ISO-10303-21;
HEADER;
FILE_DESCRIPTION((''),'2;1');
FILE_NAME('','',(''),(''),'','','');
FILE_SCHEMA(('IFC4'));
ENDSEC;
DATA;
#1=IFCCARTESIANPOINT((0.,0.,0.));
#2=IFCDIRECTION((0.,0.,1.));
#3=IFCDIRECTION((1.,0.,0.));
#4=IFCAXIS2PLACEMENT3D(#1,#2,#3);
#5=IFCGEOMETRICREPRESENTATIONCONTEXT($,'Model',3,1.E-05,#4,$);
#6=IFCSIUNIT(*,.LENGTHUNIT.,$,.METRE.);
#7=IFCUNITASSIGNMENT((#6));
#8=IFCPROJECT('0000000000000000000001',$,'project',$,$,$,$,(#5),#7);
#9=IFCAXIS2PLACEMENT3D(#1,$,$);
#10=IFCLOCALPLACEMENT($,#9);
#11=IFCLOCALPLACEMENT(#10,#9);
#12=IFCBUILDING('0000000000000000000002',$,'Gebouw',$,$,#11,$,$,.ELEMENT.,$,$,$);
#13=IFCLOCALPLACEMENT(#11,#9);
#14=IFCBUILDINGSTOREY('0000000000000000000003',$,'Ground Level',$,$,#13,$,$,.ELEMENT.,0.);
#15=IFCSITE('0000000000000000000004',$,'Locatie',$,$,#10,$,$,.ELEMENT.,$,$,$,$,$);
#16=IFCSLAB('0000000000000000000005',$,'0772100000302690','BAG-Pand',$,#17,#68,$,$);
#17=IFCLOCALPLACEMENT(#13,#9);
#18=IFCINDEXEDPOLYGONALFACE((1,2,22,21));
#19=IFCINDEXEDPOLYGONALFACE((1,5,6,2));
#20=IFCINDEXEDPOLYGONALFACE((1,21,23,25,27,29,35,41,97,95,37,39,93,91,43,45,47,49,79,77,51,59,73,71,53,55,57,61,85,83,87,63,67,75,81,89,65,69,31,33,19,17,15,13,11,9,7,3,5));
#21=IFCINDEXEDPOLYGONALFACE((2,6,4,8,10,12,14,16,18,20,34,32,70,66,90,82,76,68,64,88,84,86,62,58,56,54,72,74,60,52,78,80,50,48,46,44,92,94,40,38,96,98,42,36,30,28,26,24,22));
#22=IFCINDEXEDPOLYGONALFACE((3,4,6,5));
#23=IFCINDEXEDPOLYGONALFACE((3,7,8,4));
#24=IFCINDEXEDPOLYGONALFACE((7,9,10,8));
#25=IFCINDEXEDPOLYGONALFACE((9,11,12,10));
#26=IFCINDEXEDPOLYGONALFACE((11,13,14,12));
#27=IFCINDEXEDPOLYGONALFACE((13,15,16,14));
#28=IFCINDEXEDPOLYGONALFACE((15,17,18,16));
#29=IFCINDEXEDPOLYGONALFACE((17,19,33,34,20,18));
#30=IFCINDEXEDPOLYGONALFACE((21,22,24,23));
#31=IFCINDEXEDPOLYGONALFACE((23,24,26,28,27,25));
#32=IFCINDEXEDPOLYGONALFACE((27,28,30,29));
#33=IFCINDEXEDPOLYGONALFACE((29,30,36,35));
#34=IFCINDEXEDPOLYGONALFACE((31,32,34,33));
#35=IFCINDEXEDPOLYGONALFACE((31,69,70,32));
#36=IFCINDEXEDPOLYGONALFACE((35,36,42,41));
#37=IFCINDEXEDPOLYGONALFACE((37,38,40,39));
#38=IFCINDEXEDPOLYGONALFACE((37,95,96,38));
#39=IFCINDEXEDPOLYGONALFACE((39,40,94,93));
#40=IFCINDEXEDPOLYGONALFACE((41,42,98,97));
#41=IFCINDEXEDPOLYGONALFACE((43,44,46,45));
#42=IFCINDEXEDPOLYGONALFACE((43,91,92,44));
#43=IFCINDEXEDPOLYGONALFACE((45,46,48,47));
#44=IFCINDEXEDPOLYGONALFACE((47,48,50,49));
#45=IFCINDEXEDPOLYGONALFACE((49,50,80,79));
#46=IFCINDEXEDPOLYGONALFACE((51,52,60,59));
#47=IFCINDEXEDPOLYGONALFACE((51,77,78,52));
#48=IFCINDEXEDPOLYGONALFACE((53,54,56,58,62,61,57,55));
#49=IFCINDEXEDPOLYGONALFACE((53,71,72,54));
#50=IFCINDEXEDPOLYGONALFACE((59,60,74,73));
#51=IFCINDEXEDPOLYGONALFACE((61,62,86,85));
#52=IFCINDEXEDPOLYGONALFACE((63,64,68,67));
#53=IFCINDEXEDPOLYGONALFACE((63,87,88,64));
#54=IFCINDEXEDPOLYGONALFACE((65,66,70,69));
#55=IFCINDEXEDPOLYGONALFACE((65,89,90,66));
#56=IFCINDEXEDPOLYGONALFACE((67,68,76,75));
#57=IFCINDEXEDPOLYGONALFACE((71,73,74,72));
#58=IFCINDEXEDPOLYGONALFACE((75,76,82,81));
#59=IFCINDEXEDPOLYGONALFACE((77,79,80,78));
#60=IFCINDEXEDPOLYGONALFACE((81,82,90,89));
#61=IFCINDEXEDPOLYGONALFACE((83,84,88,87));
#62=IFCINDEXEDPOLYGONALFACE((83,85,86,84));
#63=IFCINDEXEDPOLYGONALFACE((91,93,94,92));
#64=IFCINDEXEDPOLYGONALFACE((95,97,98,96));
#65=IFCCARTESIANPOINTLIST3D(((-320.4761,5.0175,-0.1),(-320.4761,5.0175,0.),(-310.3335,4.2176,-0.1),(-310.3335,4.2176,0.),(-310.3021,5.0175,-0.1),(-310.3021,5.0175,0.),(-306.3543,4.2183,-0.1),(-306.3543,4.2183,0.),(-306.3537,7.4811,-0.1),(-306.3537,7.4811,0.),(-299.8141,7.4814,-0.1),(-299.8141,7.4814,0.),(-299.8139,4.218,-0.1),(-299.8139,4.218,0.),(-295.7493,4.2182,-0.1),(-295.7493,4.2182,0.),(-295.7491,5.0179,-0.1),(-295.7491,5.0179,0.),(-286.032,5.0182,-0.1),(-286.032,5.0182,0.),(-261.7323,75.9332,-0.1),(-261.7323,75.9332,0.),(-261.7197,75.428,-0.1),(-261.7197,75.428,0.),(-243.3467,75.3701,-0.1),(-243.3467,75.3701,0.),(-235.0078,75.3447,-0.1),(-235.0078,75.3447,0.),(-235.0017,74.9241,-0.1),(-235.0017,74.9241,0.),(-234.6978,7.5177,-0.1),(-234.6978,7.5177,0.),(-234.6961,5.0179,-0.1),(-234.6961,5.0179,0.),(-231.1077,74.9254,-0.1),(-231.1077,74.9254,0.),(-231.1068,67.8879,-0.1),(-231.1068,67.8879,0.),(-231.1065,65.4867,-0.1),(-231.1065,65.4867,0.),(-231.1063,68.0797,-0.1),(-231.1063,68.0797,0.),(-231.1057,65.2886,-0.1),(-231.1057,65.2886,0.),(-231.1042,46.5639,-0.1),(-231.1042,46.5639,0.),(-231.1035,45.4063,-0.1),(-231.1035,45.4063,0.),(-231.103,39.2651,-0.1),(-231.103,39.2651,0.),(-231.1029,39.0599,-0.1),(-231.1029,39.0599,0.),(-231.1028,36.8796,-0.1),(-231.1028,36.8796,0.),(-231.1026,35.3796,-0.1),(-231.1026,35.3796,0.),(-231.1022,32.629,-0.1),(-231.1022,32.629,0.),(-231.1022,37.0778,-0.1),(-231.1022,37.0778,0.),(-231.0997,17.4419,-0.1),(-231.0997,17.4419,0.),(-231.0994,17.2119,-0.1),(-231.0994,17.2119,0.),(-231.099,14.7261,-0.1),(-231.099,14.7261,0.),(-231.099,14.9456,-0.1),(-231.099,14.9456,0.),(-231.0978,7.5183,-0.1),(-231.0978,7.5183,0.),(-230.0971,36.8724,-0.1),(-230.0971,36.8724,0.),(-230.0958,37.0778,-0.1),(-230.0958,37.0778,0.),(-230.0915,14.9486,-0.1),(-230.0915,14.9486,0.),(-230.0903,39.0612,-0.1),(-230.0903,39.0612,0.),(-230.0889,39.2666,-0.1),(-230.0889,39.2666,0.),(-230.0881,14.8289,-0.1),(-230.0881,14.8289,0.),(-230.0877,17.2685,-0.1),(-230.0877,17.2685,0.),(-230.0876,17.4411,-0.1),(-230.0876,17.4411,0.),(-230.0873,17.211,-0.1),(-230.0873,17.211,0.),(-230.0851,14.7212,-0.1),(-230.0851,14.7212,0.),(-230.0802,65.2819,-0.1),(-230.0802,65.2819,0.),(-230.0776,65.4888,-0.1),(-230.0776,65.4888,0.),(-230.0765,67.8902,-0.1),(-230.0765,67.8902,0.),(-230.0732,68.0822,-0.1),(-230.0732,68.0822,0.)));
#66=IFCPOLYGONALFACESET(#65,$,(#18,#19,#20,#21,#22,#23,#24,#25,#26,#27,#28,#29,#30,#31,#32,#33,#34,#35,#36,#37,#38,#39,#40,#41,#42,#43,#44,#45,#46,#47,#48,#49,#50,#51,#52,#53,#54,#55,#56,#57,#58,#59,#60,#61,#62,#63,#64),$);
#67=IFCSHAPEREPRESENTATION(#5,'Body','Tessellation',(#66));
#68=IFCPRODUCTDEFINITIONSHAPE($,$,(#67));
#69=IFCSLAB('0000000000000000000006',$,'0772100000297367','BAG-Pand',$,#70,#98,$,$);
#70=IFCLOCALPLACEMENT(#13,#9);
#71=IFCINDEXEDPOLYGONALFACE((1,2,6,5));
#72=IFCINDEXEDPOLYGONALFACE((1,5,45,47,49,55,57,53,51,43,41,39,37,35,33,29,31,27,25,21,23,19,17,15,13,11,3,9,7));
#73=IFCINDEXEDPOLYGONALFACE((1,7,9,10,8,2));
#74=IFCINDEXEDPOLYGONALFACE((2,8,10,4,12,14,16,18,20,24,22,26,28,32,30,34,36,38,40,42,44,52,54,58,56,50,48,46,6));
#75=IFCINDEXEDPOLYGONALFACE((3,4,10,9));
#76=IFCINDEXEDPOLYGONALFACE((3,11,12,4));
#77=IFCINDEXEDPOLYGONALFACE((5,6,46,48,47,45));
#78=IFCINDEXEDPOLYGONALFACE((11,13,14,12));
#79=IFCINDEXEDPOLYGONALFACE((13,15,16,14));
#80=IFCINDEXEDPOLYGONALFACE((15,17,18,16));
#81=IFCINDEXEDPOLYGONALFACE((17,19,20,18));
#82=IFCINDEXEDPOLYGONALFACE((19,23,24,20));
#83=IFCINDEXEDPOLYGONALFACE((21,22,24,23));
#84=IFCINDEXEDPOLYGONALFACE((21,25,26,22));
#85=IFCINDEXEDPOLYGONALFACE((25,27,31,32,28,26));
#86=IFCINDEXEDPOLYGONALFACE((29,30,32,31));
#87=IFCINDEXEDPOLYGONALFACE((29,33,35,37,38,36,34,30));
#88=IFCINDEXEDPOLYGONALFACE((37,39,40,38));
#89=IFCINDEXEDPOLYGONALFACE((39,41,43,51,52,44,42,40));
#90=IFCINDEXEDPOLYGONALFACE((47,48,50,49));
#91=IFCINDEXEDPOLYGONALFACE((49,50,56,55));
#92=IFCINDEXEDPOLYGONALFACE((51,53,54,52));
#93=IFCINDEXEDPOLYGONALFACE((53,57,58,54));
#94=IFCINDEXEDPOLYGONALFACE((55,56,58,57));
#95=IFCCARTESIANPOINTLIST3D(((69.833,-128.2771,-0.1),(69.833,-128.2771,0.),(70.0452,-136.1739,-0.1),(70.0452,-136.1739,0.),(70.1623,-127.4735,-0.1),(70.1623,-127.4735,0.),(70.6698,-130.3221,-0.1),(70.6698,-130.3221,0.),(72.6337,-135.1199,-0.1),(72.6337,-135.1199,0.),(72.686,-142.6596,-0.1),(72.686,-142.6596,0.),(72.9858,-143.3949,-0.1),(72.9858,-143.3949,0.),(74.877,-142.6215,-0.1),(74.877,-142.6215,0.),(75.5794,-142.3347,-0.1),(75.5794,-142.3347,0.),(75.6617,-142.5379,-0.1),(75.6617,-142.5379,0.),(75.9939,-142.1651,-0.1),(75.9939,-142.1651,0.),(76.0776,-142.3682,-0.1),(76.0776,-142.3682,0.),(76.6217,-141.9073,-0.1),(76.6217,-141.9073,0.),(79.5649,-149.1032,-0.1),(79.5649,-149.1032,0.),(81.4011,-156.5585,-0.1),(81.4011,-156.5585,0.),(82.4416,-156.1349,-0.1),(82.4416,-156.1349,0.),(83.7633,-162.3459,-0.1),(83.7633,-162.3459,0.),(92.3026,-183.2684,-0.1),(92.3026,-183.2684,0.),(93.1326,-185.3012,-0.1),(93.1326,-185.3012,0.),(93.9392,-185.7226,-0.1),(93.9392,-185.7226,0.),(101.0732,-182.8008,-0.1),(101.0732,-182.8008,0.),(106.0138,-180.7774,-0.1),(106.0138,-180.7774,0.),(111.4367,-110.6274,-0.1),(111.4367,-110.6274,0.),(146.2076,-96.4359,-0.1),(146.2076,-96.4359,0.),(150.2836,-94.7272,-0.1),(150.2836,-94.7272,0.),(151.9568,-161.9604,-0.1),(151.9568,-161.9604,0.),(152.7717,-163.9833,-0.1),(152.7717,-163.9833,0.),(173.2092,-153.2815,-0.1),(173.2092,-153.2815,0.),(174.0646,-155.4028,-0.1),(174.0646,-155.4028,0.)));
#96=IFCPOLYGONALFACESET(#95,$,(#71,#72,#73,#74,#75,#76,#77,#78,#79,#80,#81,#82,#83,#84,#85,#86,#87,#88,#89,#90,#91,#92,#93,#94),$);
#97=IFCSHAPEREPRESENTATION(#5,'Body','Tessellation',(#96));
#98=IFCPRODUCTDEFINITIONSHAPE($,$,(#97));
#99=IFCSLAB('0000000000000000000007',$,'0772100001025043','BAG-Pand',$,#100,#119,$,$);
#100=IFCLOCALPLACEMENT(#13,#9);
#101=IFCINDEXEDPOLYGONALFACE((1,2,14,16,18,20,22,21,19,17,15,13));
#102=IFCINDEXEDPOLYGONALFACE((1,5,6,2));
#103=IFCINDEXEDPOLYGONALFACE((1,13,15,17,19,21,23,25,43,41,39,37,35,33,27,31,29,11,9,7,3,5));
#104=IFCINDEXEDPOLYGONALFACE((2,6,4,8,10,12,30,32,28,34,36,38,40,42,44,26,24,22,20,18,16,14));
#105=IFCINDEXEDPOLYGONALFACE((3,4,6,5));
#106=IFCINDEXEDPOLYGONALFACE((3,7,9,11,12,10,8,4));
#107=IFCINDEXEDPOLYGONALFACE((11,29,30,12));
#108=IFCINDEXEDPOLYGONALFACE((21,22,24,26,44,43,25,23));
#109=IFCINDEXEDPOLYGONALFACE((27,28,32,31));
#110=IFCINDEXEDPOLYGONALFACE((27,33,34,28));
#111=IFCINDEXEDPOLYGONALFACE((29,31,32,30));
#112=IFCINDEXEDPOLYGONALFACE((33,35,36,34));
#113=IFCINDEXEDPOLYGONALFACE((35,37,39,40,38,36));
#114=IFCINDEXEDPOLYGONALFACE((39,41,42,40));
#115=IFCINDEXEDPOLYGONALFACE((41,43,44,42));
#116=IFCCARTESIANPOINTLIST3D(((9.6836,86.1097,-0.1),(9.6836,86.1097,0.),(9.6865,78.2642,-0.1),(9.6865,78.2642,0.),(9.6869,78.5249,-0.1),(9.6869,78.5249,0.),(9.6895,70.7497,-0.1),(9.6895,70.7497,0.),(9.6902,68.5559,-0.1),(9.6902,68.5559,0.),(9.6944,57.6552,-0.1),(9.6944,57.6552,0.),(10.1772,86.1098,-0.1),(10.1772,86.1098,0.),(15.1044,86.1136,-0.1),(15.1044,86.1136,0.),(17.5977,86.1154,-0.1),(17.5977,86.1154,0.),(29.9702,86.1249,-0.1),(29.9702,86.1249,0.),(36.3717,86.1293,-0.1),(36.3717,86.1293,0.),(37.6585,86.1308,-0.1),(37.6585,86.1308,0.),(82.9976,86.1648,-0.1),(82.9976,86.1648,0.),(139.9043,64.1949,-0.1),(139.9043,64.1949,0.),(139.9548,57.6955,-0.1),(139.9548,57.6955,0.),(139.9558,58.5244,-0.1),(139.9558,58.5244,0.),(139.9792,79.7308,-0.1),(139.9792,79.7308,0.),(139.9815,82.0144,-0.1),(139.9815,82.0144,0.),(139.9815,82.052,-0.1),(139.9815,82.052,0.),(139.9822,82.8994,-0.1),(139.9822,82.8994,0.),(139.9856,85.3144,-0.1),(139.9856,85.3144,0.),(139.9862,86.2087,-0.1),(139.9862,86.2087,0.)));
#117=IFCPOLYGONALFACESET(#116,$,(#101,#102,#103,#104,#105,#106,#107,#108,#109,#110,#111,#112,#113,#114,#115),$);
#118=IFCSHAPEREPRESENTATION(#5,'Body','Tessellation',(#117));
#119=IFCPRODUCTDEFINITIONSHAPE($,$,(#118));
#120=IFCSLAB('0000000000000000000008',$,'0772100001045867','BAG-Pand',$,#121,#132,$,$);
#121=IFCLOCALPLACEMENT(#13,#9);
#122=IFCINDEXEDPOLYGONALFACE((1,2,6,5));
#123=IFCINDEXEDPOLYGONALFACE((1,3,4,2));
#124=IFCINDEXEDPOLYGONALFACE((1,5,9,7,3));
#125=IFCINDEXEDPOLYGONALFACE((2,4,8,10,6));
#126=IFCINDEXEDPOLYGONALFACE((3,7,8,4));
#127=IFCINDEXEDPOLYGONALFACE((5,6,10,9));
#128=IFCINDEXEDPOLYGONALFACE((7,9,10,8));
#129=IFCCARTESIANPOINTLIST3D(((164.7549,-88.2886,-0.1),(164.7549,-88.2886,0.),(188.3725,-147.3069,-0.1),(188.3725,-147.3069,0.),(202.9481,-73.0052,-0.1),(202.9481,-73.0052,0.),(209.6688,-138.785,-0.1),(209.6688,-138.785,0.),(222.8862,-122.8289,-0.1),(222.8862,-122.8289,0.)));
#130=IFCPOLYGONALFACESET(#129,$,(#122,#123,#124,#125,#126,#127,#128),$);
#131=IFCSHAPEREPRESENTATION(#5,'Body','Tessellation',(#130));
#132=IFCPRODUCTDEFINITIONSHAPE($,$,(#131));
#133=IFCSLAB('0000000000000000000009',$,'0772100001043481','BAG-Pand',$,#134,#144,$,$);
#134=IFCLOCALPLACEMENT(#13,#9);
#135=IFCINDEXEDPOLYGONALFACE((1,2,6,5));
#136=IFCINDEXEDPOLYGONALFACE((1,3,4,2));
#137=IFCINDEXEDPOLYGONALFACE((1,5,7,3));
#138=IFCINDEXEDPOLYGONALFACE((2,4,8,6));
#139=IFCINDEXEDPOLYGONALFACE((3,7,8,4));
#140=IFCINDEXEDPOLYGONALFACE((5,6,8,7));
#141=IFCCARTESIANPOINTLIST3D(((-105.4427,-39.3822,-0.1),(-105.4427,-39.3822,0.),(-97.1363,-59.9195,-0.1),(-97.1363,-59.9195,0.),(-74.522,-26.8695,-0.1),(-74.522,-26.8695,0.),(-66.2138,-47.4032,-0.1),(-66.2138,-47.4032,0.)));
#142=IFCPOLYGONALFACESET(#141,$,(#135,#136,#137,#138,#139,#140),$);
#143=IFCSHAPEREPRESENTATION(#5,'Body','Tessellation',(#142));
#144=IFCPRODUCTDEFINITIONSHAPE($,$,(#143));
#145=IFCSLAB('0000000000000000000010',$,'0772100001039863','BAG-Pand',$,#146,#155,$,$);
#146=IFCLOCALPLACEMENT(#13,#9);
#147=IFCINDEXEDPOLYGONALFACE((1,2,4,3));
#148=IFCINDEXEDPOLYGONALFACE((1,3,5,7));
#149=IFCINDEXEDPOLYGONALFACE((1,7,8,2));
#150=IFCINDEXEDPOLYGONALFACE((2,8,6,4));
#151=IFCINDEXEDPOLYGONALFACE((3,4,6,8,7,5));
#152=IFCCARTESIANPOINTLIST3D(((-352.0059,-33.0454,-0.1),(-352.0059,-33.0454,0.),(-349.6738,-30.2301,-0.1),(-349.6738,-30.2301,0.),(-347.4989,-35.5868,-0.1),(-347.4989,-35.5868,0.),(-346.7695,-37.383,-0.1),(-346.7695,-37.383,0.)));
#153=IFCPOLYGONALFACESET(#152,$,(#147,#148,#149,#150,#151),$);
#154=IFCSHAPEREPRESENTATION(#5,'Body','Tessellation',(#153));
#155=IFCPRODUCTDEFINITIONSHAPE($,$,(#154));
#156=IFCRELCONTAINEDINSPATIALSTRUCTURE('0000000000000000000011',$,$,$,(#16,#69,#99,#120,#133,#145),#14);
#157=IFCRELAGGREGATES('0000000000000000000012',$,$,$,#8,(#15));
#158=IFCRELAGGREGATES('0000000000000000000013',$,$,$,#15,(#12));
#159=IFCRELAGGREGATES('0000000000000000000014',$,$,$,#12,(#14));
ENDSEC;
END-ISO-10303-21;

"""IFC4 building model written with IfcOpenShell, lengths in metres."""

from ifc_helpers import new_model, si_unit, frame, origin, origin_with_axes, place, context, project, spatial, polyline, outline, extrude, element, save


model = new_model("IFC4")

# Units and contexts
model_context = context("Model", 3, precision=1e-05, world=origin_with_axes())
ifc_project = project(units=[si_unit("LENGTHUNIT", "METRE")], contexts=[model_context])

# Site, building, storey
site_placement = place(None, origin())
site = spatial("IfcSite", under=ifc_project, at=site_placement, Name="Locatie", CompositionType="ELEMENT")
building_placement = place(site_placement, origin())
building = spatial("IfcBuilding", under=site, at=building_placement, Name="Gebouw", CompositionType="ELEMENT")
storey_placement = place(building_placement, origin())
storey = spatial("IfcBuildingStorey", under=building, at=storey_placement, Name="Ground Level", CompositionType="ELEMENT", Elevation=0.0)

# Slabs
slab_1_placement = place(storey_placement, origin())
element("IfcSlab", 1, at=slab_1_placement, inside=storey, Name="0772100000302690", Description="BAG-Pand", context=model_context, shape_type="SweptSolid", body=[
    extrude(outline(polyline([(-261.7197, 75.428), (-243.3467, 75.3701), (-235.0078, 75.3447), (-235.0017, 74.9241), (-231.1077, 74.9254), (-231.1063, 68.0797), (-230.0732, 68.0822), (-230.0765, 67.8902), (-231.1068, 67.8879), (-231.1065, 65.4867), (-230.0776, 65.4888), (-230.0802, 65.2819), (-231.1057, 65.2886), (-231.1042, 46.5639), (-231.1035, 45.4063), (-231.103, 39.2651), (-230.0889, 39.2666), (-230.0903, 39.0612), (-231.1029, 39.0599), (-231.1022, 37.0778), (-230.0958, 37.0778), (-230.0971, 36.8724), (-231.1028, 36.8796), (-231.1026, 35.3796), (-231.1022, 32.629), (-231.0997, 17.4419), (-230.0876, 17.4411), (-230.0877, 17.2685), (-230.0873, 17.211), (-231.0994, 17.2119), (-231.099, 14.9456), (-230.0915, 14.9486), (-230.0881, 14.8289), (-230.0851, 14.7212), (-231.099, 14.7261), (-231.0978, 7.5183), (-234.6978, 7.5177), (-234.6961, 5.0179), (-286.032, 5.0182), (-295.7491, 5.0179), (-295.7493, 4.2182), (-299.8139, 4.218), (-299.8141, 7.4814), (-306.3537, 7.4811), (-306.3543, 4.2183), (-310.3335, 4.2176), (-310.3021, 5.0175), (-320.4761, 5.0175), (-261.7323, 75.9332), (-261.7197, 75.428)])), frame((0.0, 0.0, -0.1), z_axis=(0.0, 0.0, 1.0), x_axis=(1.0, 0.0, 0.0)), (0.0, 0.0, 1.0), 0.1),
])
slab_2_placement = place(storey_placement, origin())
element("IfcSlab", 2, at=slab_2_placement, inside=storey, Name="0772100000297367", Description="BAG-Pand", context=model_context, shape_type="SweptSolid", body=[
    extrude(outline(polyline([(92.3026, -183.2684), (83.7633, -162.3459), (81.4011, -156.5585), (82.4416, -156.1349), (79.5649, -149.1032), (76.6217, -141.9073), (75.9939, -142.1651), (76.0776, -142.3682), (75.6617, -142.5379), (75.5794, -142.3347), (74.877, -142.6215), (72.9858, -143.3949), (72.686, -142.6596), (70.0452, -136.1739), (72.6337, -135.1199), (70.6698, -130.3221), (69.833, -128.2771), (70.1623, -127.4735), (111.4367, -110.6274), (146.2076, -96.4359), (150.2836, -94.7272), (173.2092, -153.2815), (174.0646, -155.4028), (152.7717, -163.9833), (151.9568, -161.9604), (106.0138, -180.7774), (101.0732, -182.8008), (93.9392, -185.7226), (93.1326, -185.3012), (92.3026, -183.2684)])), frame((0.0, 0.0, -0.1), z_axis=(0.0, 0.0, 1.0), x_axis=(1.0, 0.0, 0.0)), (0.0, 0.0, 1.0), 0.1),
])
slab_3_placement = place(storey_placement, origin())
element("IfcSlab", 3, at=slab_3_placement, inside=storey, Name="0772100001025043", Description="BAG-Pand", context=model_context, shape_type="SweptSolid", body=[
    extrude(outline(polyline([(9.6902, 68.5559), (9.6895, 70.7497), (9.6865, 78.2642), (9.6869, 78.5249), (9.6836, 86.1097), (10.1772, 86.1098), (15.1044, 86.1136), (17.5977, 86.1154), (29.9702, 86.1249), (36.3717, 86.1293), (37.6585, 86.1308), (82.9976, 86.1648), (139.9862, 86.2087), (139.9856, 85.3144), (139.9822, 82.8994), (139.9815, 82.052), (139.9815, 82.0144), (139.9792, 79.7308), (139.9043, 64.1949), (139.9558, 58.5244), (139.9548, 57.6955), (9.6944, 57.6552), (9.6902, 68.5559)])), frame((0.0, 0.0, -0.1), z_axis=(0.0, 0.0, 1.0), x_axis=(1.0, 0.0, 0.0)), (0.0, 0.0, 1.0), 0.1),
])
slab_4_placement = place(storey_placement, origin())
element("IfcSlab", 4, at=slab_4_placement, inside=storey, Name="0772100001045867", Description="BAG-Pand", context=model_context, shape_type="SweptSolid", body=[
    extrude(outline(polyline([(188.3725, -147.3069), (164.7549, -88.2886), (202.9481, -73.0052), (222.8862, -122.8289), (209.6688, -138.785), (188.3725, -147.3069)])), frame((0.0, 0.0, -0.1), z_axis=(0.0, 0.0, 1.0), x_axis=(1.0, 0.0, 0.0)), (0.0, 0.0, 1.0), 0.1),
])
slab_5_placement = place(storey_placement, origin())
element("IfcSlab", 5, at=slab_5_placement, inside=storey, Name="0772100001043481", Description="BAG-Pand", context=model_context, shape_type="SweptSolid", body=[
    extrude(outline(polyline([(-105.4427, -39.3822), (-74.522, -26.8695), (-66.2138, -47.4032), (-97.1363, -59.9195), (-105.4427, -39.3822)])), frame((0.0, 0.0, -0.1), z_axis=(0.0, 0.0, 1.0), x_axis=(1.0, 0.0, 0.0)), (0.0, 0.0, 1.0), 0.1),
])
slab_6_placement = place(storey_placement, origin())
element("IfcSlab", 6, at=slab_6_placement, inside=storey, Name="0772100001039863", Description="BAG-Pand", context=model_context, shape_type="SweptSolid", body=[
    extrude(outline(polyline([(-347.4989, -35.5868), (-346.7695, -37.383), (-352.0059, -33.0454), (-349.6738, -30.2301), (-347.4989, -35.5868)])), frame((0.0, 0.0, -0.1), z_axis=(0.0, 0.0, 1.0), x_axis=(1.0, 0.0, 0.0)), (0.0, 0.0, 1.0), 0.1),
])

save(model, "model.ifc")
